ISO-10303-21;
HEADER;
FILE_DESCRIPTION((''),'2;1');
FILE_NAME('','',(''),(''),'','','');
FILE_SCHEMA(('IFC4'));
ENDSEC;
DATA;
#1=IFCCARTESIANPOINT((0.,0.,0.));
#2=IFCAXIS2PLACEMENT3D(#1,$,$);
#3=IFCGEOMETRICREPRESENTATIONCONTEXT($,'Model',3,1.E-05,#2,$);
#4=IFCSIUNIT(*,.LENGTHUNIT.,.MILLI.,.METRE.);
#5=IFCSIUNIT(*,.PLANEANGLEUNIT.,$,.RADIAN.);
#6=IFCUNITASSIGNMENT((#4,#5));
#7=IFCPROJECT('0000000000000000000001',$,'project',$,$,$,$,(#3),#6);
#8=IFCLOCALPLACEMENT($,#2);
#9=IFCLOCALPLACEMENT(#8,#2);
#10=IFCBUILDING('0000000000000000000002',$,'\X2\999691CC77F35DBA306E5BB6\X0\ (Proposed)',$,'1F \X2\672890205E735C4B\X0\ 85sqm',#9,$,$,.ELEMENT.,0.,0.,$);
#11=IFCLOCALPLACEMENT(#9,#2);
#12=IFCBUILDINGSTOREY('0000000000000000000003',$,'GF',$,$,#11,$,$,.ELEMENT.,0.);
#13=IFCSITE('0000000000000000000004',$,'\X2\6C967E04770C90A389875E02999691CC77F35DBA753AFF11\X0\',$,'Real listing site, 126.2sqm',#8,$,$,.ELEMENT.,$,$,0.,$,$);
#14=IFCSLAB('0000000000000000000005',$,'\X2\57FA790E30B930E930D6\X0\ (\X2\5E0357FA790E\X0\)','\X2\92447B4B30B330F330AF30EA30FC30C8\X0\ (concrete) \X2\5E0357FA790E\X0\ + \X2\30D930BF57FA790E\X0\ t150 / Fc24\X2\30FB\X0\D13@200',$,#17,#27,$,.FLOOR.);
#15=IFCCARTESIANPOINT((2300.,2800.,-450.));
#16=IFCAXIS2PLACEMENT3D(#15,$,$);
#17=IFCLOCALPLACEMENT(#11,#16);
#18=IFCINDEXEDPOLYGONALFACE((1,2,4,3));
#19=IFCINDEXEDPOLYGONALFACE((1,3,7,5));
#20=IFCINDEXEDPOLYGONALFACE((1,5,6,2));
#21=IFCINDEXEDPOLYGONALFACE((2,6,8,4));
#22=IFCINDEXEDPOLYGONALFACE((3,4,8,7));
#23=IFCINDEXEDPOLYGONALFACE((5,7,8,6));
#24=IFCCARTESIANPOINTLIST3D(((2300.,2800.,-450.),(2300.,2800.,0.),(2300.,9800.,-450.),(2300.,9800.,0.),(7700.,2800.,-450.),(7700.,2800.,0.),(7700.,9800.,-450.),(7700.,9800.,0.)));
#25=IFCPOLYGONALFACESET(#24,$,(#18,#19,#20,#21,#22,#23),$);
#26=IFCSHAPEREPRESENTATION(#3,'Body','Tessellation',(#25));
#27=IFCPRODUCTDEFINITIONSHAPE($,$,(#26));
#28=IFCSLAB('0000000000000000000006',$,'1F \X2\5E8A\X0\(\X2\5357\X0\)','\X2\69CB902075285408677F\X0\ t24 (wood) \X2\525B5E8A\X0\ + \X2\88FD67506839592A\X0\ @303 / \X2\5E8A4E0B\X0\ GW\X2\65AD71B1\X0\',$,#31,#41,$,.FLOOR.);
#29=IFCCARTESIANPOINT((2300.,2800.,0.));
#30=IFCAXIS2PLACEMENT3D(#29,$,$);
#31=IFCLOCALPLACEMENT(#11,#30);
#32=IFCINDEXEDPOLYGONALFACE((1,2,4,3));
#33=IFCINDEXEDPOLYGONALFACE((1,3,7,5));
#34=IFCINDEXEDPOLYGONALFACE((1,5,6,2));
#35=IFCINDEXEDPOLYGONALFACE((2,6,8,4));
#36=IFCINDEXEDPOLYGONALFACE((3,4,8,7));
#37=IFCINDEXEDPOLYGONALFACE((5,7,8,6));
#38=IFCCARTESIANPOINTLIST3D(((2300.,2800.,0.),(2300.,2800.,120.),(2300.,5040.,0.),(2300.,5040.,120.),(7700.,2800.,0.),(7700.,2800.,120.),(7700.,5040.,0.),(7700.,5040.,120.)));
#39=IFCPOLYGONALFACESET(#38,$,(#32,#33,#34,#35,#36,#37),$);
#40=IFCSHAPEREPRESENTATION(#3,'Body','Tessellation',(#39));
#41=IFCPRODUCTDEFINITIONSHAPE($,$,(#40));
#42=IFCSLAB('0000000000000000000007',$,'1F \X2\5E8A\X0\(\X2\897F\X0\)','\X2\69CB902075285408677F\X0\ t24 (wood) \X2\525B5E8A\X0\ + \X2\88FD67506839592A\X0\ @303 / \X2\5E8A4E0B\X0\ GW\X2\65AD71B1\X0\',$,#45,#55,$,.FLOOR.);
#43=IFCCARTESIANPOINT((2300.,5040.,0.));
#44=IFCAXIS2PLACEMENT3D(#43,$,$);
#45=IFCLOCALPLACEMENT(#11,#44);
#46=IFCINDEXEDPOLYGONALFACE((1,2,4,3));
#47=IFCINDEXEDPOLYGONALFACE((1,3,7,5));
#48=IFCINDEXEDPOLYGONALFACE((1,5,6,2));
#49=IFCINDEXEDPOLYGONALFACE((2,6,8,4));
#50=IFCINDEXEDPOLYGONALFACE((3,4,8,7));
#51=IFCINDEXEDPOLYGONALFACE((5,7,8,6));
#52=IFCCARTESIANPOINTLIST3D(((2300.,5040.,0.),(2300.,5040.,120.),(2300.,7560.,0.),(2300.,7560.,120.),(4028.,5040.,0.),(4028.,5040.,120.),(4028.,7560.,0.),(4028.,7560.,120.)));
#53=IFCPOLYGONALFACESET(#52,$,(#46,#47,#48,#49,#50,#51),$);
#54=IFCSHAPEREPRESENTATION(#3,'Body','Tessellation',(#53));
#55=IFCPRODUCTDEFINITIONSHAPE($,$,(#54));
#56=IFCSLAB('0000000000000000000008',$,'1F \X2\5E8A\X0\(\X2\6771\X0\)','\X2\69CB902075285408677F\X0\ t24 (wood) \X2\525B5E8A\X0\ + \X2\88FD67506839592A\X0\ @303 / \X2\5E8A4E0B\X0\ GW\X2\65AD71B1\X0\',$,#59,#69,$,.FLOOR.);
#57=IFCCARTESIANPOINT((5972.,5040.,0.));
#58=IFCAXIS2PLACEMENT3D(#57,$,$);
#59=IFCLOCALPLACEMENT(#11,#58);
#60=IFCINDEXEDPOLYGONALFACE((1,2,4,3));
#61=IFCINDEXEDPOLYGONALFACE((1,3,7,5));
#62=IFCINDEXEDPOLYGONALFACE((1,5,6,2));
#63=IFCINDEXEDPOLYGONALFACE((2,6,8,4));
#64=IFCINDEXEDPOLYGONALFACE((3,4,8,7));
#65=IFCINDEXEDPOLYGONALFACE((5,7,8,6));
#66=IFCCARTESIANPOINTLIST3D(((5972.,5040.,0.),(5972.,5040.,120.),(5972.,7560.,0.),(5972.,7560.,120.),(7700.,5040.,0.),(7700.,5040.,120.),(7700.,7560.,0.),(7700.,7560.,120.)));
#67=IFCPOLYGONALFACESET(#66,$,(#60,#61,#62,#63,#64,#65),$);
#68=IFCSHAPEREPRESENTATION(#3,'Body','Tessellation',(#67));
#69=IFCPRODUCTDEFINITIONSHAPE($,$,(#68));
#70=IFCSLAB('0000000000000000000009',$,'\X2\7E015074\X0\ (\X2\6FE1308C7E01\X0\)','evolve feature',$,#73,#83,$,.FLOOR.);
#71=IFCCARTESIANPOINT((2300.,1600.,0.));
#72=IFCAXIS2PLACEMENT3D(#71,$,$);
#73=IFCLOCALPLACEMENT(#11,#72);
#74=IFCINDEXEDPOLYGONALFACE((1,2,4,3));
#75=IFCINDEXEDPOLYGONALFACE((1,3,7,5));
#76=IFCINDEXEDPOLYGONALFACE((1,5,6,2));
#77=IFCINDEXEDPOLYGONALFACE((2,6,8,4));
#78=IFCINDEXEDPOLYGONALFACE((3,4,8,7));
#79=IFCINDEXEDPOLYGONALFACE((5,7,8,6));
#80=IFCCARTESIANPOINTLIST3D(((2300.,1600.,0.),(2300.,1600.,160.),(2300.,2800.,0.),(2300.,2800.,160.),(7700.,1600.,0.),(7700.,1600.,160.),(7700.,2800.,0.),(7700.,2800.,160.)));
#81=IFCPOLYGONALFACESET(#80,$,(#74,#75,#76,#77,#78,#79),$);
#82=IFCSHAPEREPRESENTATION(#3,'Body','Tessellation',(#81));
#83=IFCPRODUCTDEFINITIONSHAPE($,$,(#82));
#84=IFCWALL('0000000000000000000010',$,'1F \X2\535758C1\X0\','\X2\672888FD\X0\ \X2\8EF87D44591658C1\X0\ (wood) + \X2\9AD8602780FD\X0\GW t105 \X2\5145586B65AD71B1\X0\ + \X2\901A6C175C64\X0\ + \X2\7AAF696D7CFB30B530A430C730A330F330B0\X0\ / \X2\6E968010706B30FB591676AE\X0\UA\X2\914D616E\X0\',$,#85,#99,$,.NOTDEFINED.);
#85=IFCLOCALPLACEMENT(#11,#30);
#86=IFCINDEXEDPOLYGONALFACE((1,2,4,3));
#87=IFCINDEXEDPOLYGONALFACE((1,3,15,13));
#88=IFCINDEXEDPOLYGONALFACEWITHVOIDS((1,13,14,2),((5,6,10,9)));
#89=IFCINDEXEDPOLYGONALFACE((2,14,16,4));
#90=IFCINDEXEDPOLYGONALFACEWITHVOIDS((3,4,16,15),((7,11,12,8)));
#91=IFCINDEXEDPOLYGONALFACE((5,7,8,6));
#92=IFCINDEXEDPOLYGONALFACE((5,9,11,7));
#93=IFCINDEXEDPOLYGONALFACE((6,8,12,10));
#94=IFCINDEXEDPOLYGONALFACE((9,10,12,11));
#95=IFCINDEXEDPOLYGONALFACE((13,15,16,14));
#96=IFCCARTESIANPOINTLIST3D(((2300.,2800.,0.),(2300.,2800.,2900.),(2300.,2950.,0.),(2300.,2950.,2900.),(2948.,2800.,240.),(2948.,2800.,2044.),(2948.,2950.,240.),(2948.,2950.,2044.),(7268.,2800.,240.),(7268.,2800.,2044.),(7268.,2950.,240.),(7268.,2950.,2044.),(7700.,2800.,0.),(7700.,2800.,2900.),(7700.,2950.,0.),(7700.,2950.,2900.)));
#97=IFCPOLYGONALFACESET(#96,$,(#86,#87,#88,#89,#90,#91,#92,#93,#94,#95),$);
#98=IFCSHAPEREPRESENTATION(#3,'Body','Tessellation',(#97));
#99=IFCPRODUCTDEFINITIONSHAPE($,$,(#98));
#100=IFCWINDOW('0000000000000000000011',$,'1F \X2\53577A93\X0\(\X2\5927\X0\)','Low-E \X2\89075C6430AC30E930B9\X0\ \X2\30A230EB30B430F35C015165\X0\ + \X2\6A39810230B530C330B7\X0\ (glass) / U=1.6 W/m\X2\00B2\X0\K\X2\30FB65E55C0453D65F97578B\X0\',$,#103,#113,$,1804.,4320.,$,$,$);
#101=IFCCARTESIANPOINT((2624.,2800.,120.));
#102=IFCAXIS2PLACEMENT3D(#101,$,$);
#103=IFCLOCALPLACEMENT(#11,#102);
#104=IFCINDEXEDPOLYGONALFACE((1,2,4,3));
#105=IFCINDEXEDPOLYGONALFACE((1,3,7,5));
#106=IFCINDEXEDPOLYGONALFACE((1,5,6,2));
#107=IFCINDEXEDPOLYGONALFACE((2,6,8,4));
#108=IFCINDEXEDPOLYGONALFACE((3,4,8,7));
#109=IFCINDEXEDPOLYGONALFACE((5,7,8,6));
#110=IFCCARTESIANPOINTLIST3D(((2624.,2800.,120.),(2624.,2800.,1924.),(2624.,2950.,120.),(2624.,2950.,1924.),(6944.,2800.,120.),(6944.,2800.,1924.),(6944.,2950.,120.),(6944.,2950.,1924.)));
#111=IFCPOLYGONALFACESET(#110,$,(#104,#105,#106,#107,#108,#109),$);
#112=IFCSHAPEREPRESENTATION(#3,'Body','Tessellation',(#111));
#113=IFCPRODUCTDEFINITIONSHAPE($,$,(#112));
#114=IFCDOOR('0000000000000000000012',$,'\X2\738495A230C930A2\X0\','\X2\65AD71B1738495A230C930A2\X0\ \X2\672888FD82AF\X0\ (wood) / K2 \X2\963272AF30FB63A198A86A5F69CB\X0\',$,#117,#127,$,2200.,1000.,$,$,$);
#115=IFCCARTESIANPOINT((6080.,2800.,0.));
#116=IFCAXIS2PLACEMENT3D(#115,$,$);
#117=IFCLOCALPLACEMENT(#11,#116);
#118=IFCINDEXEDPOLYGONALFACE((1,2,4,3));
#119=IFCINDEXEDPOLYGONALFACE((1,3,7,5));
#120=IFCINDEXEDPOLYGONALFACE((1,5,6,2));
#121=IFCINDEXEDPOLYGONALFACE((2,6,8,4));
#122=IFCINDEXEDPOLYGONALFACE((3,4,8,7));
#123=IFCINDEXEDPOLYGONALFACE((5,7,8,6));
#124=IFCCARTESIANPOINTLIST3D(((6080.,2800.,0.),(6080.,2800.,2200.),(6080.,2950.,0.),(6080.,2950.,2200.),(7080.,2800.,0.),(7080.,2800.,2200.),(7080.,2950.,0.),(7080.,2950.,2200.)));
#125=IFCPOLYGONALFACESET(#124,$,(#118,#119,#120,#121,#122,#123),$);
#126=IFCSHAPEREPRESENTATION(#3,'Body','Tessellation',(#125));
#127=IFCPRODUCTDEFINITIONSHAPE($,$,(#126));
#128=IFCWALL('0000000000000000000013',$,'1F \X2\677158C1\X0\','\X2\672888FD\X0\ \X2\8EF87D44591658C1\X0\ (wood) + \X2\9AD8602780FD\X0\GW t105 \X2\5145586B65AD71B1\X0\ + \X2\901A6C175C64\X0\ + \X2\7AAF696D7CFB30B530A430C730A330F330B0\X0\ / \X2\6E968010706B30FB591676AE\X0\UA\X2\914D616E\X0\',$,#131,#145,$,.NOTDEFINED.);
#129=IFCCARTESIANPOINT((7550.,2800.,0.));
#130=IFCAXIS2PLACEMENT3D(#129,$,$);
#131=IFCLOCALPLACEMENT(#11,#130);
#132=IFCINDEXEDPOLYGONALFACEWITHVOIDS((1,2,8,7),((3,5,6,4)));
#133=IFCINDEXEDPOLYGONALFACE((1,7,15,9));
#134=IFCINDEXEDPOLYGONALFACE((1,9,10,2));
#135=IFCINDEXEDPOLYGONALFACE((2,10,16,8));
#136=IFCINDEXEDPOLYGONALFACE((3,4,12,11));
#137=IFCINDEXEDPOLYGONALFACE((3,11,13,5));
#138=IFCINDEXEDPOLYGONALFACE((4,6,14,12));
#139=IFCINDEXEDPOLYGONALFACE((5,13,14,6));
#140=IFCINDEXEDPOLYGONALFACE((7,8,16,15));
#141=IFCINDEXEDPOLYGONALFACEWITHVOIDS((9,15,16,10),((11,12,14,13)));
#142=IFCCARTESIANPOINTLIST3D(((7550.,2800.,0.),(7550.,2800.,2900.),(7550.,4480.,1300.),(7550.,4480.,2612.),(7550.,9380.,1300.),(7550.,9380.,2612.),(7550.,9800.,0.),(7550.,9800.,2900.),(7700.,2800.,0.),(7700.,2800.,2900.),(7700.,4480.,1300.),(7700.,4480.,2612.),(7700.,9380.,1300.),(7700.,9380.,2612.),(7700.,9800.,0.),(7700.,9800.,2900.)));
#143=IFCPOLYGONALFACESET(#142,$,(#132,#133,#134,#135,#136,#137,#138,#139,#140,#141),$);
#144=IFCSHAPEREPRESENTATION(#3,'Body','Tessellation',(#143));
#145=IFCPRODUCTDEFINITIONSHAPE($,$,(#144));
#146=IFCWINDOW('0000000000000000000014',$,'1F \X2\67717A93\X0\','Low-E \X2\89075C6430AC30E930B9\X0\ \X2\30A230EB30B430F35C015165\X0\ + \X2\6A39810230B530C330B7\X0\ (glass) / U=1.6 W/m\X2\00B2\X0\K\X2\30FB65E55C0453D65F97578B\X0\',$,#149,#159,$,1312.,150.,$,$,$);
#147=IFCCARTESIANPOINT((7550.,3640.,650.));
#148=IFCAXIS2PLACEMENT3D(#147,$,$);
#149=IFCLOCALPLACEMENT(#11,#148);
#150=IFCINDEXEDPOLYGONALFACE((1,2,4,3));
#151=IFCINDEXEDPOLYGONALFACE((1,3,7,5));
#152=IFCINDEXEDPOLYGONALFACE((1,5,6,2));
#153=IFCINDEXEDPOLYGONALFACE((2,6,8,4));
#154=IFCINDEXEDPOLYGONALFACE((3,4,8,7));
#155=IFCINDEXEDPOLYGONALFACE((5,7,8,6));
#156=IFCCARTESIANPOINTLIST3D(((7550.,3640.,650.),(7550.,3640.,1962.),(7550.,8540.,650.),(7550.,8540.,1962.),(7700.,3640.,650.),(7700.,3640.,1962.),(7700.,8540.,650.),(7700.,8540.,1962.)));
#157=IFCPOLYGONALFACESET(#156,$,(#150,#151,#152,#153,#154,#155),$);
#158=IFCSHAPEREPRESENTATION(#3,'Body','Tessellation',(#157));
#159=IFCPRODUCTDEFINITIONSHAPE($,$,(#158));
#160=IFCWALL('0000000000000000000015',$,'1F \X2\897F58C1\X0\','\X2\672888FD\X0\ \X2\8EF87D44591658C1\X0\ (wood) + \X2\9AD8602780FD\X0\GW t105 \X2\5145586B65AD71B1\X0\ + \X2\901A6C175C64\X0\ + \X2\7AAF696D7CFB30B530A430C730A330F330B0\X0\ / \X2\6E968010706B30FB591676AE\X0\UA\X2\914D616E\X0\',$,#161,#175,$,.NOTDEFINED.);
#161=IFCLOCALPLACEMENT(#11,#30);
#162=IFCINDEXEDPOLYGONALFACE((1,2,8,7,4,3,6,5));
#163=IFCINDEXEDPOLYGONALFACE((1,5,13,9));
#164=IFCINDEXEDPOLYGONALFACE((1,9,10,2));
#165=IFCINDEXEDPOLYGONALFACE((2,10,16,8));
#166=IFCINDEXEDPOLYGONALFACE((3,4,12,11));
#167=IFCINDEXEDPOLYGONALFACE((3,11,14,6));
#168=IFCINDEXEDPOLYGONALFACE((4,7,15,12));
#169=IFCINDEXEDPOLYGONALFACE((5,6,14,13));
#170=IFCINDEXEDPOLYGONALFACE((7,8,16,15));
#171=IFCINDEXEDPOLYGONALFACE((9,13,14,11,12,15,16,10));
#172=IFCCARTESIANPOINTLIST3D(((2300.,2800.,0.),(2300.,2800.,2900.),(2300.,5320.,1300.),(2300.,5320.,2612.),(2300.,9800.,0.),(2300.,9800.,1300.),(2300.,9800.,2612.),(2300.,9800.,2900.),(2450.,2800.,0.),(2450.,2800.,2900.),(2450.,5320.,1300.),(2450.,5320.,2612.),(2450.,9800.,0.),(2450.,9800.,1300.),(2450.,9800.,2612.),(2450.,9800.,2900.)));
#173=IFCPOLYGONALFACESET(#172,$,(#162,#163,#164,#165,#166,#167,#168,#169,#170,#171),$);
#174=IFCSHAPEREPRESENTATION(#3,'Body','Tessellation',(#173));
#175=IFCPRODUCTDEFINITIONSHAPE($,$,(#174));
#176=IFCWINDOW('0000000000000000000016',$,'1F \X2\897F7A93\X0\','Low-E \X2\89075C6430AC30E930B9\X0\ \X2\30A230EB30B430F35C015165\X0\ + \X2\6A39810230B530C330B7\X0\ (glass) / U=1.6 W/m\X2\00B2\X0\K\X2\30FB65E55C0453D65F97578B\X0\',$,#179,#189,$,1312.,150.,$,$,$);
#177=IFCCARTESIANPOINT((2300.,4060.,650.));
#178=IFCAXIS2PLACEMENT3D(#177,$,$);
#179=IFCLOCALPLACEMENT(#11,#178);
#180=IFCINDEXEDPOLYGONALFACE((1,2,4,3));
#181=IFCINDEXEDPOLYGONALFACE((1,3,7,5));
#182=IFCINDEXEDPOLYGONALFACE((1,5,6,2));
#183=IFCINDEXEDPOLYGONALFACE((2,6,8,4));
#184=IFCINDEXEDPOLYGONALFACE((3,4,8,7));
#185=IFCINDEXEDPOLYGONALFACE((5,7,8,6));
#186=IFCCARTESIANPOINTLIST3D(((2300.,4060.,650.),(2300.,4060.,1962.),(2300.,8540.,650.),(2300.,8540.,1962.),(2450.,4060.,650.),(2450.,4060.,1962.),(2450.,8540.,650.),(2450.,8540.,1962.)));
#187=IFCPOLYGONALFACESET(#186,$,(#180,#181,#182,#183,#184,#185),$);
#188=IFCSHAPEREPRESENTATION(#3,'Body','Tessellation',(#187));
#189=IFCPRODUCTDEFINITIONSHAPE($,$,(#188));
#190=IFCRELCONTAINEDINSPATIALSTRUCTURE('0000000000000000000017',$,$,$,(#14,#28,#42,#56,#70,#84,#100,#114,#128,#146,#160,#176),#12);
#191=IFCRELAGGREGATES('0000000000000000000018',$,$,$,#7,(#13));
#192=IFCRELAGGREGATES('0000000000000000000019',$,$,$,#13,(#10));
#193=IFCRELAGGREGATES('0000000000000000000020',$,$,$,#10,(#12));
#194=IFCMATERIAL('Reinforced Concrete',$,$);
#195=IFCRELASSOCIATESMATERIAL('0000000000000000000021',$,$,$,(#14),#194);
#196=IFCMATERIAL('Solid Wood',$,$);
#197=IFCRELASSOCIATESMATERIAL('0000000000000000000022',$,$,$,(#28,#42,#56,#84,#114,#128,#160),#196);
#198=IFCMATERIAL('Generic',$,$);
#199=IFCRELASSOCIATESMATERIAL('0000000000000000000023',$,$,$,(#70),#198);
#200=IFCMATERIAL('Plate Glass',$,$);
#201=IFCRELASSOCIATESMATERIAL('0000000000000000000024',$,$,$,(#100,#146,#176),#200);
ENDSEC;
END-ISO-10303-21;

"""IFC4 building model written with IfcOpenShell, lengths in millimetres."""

from ifc_helpers import new_model, si_unit, frame, frame_2d, origin, place, context, project, spatial, rectangle, extrude, material, element, fill, save


model = new_model("IFC4")

# Units and contexts
model_context = context("Model", 3, precision=1e-05, world=origin())
ifc_project = project(units=[si_unit("LENGTHUNIT", "METRE", prefix="MILLI"), si_unit("PLANEANGLEUNIT", "RADIAN")], contexts=[model_context])

# Site, building, storey
site_placement = place(None, origin())
site = spatial("IfcSite", under=ifc_project, at=site_placement, Name="沖縄県那覇市首里石嶺町１", ObjectType="Real listing site, 126.2sqm", CompositionType="ELEMENT", RefElevation=0.0)
building_placement = place(site_placement, origin())
building = spatial("IfcBuilding", under=site, at=building_placement, Name="首里石嶺の家 (Proposed)", ObjectType="1F 木造平屋 85sqm", CompositionType="ELEMENT", ElevationOfRefHeight=0.0, ElevationOfTerrain=0.0)
storey_placement = place(building_placement, origin())
storey = spatial("IfcBuildingStorey", under=building, at=storey_placement, Name="GF", CompositionType="ELEMENT", Elevation=0.0)

# Slabs
ifc_material_1 = material(Name="Reinforced Concrete")
slab_1_placement = place(storey_placement, frame((2300.0, 2800.0, -450.0)))
element("IfcSlab", 1, at=slab_1_placement, inside=storey, material=ifc_material_1, Name="基礎スラブ (布基礎)", Description="鉄筋コンクリート (concrete) 布基礎 + ベタ基礎 t150 / Fc24・D13@200", PredefinedType="FLOOR", context=model_context, shape_type="SweptSolid", body=[
    extrude(rectangle(XDim=5400.0, YDim=7000.0, at=frame_2d((2700.0, 3500.0))), frame((2300.0, 2800.0, -450.0)), (0.0, 0.0, 1.0), 450.0),
])
ifc_material_2 = material(Name="Solid Wood")
slab_2_placement = place(storey_placement, frame((2300.0, 2800.0, 0.0)))
element("IfcSlab", 2, at=slab_2_placement, inside=storey, material=ifc_material_2, Name="1F 床(南)", Description="構造用合板 t24 (wood) 剛床 + 製材根太 @303 / 床下 GW断熱", PredefinedType="FLOOR", context=model_context, shape_type="SweptSolid", body=[
    extrude(rectangle(XDim=5400.0, YDim=2240.0, at=frame_2d((2700.0, 1120.0))), frame((2300.0, 2800.0, 0.0)), (0.0, 0.0, 1.0), 120.0),
])
slab_3_placement = place(storey_placement, frame((2300.0, 5040.0, 0.0)))
element("IfcSlab", 3, at=slab_3_placement, inside=storey, material=ifc_material_2, Name="1F 床(西)", Description="構造用合板 t24 (wood) 剛床 + 製材根太 @303 / 床下 GW断熱", PredefinedType="FLOOR", context=model_context, shape_type="SweptSolid", body=[
    extrude(rectangle(XDim=1728.0, YDim=2520.0, at=frame_2d((864.0, 1260.0))), frame((2300.0, 5040.0, 0.0)), (0.0, 0.0, 1.0), 120.0),
])
slab_4_placement = place(storey_placement, frame((5972.0, 5040.0, 0.0)))
element("IfcSlab", 4, at=slab_4_placement, inside=storey, material=ifc_material_2, Name="1F 床(東)", Description="構造用合板 t24 (wood) 剛床 + 製材根太 @303 / 床下 GW断熱", PredefinedType="FLOOR", context=model_context, shape_type="SweptSolid", body=[
    extrude(rectangle(XDim=1728.0, YDim=2520.0, at=frame_2d((864.0, 1260.0))), frame((5972.0, 5040.0, 0.0)), (0.0, 0.0, 1.0), 120.0),
])
ifc_material_3 = material(Name="Generic")
slab_5_placement = place(storey_placement, frame((2300.0, 1600.0, 0.0)))
element("IfcSlab", 5, at=slab_5_placement, inside=storey, material=ifc_material_3, Name="縁側 (濡れ縁)", Description="evolve feature", PredefinedType="FLOOR", context=model_context, shape_type="SweptSolid", body=[
    extrude(rectangle(XDim=5400.0, YDim=1200.0, at=frame_2d((2700.0, 600.0))), frame((2300.0, 1600.0, 0.0)), (0.0, 0.0, 1.0), 160.0),
])

# Wall, openings, window, door
wall_1_placement = place(storey_placement, frame((2300.0, 2800.0, 0.0)))
wall_1 = element("IfcWall", 6, at=wall_1_placement, inside=storey, material=ifc_material_2, Name="1F 南壁", Description="木製 軸組外壁 (wood) + 高性能GW t105 充填断熱 + 通気層 + 窯業系サイディング / 準耐火・外皮UA配慮", PredefinedType="NOTDEFINED", context=model_context, shape_type="SweptSolid", body=[
    extrude(rectangle(XDim=5400.0, YDim=150.0, at=frame_2d((2700.0, 75.0))), frame((2300.0, 2800.0, 0.0)), (0.0, 0.0, 1.0), 2900.0),
])
opening_1_placement = place(storey_placement, frame((2624.0, 2800.0, 120.0)))
opening_1 = element("IfcOpeningElement", 7, at=opening_1_placement, cuts=wall_1, PredefinedType="NOTDEFINED", context=model_context, shape_type="SweptSolid", body=[
    extrude(rectangle(XDim=4320.0, YDim=150.0, at=frame_2d((2160.0, 75.0))), frame((2624.0, 2800.0, 120.0)), (0.0, 0.0, 1.0), 1804.0),
])
opening_2_placement = place(storey_placement, frame((6080.0, 2800.0, 0.0)))
opening_2 = element("IfcOpeningElement", 8, at=opening_2_placement, cuts=wall_1, PredefinedType="NOTDEFINED", context=model_context, shape_type="SweptSolid", body=[
    extrude(rectangle(XDim=1000.0, YDim=150.0, at=frame_2d((500.0, 75.0))), frame((6080.0, 2800.0, 0.0)), (0.0, 0.0, 1.0), 2200.0),
])
ifc_material_4 = material(Name="Plate Glass")
window_1_placement = place(storey_placement, frame((2624.0, 2800.0, 120.0)))
window_1 = element("IfcWindow", 9, at=window_1_placement, inside=storey, material=ifc_material_4, Name="1F 南窓(大)", Description="Low-E 複層ガラス アルゴン封入 + 樹脂サッシ (glass) / U=1.6 W/m²K・日射取得型", OverallHeight=1804.0, OverallWidth=4320.0, context=model_context, shape_type="SweptSolid", body=[
    extrude(rectangle(XDim=4320.0, YDim=150.0, at=frame_2d((2160.0, 75.0))), frame((2624.0, 2800.0, 120.0)), (0.0, 0.0, 1.0), 1804.0),
])
fill(opening_1, window_1)
door_placement = place(storey_placement, frame((6080.0, 2800.0, 0.0)))
door = element("IfcDoor", 10, at=door_placement, inside=storey, material=ifc_material_2, Name="玄関ドア", Description="断熱玄関ドア 木製芯 (wood) / K2 防犯・採風機構", OverallHeight=2200.0, OverallWidth=1000.0, context=model_context, shape_type="SweptSolid", body=[
    extrude(rectangle(XDim=1000.0, YDim=150.0, at=frame_2d((500.0, 75.0))), frame((6080.0, 2800.0, 0.0)), (0.0, 0.0, 1.0), 2200.0),
])
fill(opening_2, door)

# Walls, openings, windows
wall_2_placement = place(storey_placement, frame((7550.0, 2800.0, 0.0)))
wall_2 = element("IfcWall", 11, at=wall_2_placement, inside=storey, material=ifc_material_2, Name="1F 東壁", Description="木製 軸組外壁 (wood) + 高性能GW t105 充填断熱 + 通気層 + 窯業系サイディング / 準耐火・外皮UA配慮", PredefinedType="NOTDEFINED", context=model_context, shape_type="SweptSolid", body=[
    extrude(rectangle(XDim=150.0, YDim=7000.0, at=frame_2d((75.0, 3500.0))), frame((7550.0, 2800.0, 0.0)), (0.0, 0.0, 1.0), 2900.0),
])
opening_3_placement = place(storey_placement, frame((7550.0, 3640.0, 650.0)))
opening_3 = element("IfcOpeningElement", 12, at=opening_3_placement, cuts=wall_2, PredefinedType="NOTDEFINED", context=model_context, shape_type="SweptSolid", body=[
    extrude(rectangle(XDim=150.0, YDim=4900.0, at=frame_2d((75.0, 2450.0))), frame((7550.0, 3640.0, 650.0)), (0.0, 0.0, 1.0), 1312.0),
])
window_2_placement = place(storey_placement, frame((7550.0, 3640.0, 650.0)))
window_2 = element("IfcWindow", 13, at=window_2_placement, inside=storey, material=ifc_material_4, Name="1F 東窓", Description="Low-E 複層ガラス アルゴン封入 + 樹脂サッシ (glass) / U=1.6 W/m²K・日射取得型", OverallHeight=1312.0, OverallWidth=150.0, context=model_context, shape_type="SweptSolid", body=[
    extrude(rectangle(XDim=150.0, YDim=4900.0, at=frame_2d((75.0, 2450.0))), frame((7550.0, 3640.0, 650.0)), (0.0, 0.0, 1.0), 1312.0),
])
fill(opening_3, window_2)
wall_3_placement = place(storey_placement, frame((2300.0, 2800.0, 0.0)))
wall_3 = element("IfcWall", 14, at=wall_3_placement, inside=storey, material=ifc_material_2, Name="1F 西壁", Description="木製 軸組外壁 (wood) + 高性能GW t105 充填断熱 + 通気層 + 窯業系サイディング / 準耐火・外皮UA配慮", PredefinedType="NOTDEFINED", context=model_context, shape_type="SweptSolid", body=[
    extrude(rectangle(XDim=150.0, YDim=7000.0, at=frame_2d((75.0, 3500.0))), frame((2300.0, 2800.0, 0.0)), (0.0, 0.0, 1.0), 2900.0),
])
opening_4_placement = place(storey_placement, frame((2300.0, 4060.0, 650.0)))
opening_4 = element("IfcOpeningElement", 15, at=opening_4_placement, cuts=wall_3, PredefinedType="NOTDEFINED", context=model_context, shape_type="SweptSolid", body=[
    extrude(rectangle(XDim=150.0, YDim=4480.0, at=frame_2d((75.0, 2240.0))), frame((2300.0, 4060.0, 650.0)), (0.0, 0.0, 1.0), 1312.0),
])
window_3_placement = place(storey_placement, frame((2300.0, 4060.0, 650.0)))
window_3 = element("IfcWindow", 16, at=window_3_placement, inside=storey, material=ifc_material_4, Name="1F 西窓", Description="Low-E 複層ガラス アルゴン封入 + 樹脂サッシ (glass) / U=1.6 W/m²K・日射取得型", OverallHeight=1312.0, OverallWidth=150.0, context=model_context, shape_type="SweptSolid", body=[
    extrude(rectangle(XDim=150.0, YDim=4480.0, at=frame_2d((75.0, 2240.0))), frame((2300.0, 4060.0, 650.0)), (0.0, 0.0, 1.0), 1312.0),
])
fill(opening_4, window_3)

save(model, "model.ifc")
